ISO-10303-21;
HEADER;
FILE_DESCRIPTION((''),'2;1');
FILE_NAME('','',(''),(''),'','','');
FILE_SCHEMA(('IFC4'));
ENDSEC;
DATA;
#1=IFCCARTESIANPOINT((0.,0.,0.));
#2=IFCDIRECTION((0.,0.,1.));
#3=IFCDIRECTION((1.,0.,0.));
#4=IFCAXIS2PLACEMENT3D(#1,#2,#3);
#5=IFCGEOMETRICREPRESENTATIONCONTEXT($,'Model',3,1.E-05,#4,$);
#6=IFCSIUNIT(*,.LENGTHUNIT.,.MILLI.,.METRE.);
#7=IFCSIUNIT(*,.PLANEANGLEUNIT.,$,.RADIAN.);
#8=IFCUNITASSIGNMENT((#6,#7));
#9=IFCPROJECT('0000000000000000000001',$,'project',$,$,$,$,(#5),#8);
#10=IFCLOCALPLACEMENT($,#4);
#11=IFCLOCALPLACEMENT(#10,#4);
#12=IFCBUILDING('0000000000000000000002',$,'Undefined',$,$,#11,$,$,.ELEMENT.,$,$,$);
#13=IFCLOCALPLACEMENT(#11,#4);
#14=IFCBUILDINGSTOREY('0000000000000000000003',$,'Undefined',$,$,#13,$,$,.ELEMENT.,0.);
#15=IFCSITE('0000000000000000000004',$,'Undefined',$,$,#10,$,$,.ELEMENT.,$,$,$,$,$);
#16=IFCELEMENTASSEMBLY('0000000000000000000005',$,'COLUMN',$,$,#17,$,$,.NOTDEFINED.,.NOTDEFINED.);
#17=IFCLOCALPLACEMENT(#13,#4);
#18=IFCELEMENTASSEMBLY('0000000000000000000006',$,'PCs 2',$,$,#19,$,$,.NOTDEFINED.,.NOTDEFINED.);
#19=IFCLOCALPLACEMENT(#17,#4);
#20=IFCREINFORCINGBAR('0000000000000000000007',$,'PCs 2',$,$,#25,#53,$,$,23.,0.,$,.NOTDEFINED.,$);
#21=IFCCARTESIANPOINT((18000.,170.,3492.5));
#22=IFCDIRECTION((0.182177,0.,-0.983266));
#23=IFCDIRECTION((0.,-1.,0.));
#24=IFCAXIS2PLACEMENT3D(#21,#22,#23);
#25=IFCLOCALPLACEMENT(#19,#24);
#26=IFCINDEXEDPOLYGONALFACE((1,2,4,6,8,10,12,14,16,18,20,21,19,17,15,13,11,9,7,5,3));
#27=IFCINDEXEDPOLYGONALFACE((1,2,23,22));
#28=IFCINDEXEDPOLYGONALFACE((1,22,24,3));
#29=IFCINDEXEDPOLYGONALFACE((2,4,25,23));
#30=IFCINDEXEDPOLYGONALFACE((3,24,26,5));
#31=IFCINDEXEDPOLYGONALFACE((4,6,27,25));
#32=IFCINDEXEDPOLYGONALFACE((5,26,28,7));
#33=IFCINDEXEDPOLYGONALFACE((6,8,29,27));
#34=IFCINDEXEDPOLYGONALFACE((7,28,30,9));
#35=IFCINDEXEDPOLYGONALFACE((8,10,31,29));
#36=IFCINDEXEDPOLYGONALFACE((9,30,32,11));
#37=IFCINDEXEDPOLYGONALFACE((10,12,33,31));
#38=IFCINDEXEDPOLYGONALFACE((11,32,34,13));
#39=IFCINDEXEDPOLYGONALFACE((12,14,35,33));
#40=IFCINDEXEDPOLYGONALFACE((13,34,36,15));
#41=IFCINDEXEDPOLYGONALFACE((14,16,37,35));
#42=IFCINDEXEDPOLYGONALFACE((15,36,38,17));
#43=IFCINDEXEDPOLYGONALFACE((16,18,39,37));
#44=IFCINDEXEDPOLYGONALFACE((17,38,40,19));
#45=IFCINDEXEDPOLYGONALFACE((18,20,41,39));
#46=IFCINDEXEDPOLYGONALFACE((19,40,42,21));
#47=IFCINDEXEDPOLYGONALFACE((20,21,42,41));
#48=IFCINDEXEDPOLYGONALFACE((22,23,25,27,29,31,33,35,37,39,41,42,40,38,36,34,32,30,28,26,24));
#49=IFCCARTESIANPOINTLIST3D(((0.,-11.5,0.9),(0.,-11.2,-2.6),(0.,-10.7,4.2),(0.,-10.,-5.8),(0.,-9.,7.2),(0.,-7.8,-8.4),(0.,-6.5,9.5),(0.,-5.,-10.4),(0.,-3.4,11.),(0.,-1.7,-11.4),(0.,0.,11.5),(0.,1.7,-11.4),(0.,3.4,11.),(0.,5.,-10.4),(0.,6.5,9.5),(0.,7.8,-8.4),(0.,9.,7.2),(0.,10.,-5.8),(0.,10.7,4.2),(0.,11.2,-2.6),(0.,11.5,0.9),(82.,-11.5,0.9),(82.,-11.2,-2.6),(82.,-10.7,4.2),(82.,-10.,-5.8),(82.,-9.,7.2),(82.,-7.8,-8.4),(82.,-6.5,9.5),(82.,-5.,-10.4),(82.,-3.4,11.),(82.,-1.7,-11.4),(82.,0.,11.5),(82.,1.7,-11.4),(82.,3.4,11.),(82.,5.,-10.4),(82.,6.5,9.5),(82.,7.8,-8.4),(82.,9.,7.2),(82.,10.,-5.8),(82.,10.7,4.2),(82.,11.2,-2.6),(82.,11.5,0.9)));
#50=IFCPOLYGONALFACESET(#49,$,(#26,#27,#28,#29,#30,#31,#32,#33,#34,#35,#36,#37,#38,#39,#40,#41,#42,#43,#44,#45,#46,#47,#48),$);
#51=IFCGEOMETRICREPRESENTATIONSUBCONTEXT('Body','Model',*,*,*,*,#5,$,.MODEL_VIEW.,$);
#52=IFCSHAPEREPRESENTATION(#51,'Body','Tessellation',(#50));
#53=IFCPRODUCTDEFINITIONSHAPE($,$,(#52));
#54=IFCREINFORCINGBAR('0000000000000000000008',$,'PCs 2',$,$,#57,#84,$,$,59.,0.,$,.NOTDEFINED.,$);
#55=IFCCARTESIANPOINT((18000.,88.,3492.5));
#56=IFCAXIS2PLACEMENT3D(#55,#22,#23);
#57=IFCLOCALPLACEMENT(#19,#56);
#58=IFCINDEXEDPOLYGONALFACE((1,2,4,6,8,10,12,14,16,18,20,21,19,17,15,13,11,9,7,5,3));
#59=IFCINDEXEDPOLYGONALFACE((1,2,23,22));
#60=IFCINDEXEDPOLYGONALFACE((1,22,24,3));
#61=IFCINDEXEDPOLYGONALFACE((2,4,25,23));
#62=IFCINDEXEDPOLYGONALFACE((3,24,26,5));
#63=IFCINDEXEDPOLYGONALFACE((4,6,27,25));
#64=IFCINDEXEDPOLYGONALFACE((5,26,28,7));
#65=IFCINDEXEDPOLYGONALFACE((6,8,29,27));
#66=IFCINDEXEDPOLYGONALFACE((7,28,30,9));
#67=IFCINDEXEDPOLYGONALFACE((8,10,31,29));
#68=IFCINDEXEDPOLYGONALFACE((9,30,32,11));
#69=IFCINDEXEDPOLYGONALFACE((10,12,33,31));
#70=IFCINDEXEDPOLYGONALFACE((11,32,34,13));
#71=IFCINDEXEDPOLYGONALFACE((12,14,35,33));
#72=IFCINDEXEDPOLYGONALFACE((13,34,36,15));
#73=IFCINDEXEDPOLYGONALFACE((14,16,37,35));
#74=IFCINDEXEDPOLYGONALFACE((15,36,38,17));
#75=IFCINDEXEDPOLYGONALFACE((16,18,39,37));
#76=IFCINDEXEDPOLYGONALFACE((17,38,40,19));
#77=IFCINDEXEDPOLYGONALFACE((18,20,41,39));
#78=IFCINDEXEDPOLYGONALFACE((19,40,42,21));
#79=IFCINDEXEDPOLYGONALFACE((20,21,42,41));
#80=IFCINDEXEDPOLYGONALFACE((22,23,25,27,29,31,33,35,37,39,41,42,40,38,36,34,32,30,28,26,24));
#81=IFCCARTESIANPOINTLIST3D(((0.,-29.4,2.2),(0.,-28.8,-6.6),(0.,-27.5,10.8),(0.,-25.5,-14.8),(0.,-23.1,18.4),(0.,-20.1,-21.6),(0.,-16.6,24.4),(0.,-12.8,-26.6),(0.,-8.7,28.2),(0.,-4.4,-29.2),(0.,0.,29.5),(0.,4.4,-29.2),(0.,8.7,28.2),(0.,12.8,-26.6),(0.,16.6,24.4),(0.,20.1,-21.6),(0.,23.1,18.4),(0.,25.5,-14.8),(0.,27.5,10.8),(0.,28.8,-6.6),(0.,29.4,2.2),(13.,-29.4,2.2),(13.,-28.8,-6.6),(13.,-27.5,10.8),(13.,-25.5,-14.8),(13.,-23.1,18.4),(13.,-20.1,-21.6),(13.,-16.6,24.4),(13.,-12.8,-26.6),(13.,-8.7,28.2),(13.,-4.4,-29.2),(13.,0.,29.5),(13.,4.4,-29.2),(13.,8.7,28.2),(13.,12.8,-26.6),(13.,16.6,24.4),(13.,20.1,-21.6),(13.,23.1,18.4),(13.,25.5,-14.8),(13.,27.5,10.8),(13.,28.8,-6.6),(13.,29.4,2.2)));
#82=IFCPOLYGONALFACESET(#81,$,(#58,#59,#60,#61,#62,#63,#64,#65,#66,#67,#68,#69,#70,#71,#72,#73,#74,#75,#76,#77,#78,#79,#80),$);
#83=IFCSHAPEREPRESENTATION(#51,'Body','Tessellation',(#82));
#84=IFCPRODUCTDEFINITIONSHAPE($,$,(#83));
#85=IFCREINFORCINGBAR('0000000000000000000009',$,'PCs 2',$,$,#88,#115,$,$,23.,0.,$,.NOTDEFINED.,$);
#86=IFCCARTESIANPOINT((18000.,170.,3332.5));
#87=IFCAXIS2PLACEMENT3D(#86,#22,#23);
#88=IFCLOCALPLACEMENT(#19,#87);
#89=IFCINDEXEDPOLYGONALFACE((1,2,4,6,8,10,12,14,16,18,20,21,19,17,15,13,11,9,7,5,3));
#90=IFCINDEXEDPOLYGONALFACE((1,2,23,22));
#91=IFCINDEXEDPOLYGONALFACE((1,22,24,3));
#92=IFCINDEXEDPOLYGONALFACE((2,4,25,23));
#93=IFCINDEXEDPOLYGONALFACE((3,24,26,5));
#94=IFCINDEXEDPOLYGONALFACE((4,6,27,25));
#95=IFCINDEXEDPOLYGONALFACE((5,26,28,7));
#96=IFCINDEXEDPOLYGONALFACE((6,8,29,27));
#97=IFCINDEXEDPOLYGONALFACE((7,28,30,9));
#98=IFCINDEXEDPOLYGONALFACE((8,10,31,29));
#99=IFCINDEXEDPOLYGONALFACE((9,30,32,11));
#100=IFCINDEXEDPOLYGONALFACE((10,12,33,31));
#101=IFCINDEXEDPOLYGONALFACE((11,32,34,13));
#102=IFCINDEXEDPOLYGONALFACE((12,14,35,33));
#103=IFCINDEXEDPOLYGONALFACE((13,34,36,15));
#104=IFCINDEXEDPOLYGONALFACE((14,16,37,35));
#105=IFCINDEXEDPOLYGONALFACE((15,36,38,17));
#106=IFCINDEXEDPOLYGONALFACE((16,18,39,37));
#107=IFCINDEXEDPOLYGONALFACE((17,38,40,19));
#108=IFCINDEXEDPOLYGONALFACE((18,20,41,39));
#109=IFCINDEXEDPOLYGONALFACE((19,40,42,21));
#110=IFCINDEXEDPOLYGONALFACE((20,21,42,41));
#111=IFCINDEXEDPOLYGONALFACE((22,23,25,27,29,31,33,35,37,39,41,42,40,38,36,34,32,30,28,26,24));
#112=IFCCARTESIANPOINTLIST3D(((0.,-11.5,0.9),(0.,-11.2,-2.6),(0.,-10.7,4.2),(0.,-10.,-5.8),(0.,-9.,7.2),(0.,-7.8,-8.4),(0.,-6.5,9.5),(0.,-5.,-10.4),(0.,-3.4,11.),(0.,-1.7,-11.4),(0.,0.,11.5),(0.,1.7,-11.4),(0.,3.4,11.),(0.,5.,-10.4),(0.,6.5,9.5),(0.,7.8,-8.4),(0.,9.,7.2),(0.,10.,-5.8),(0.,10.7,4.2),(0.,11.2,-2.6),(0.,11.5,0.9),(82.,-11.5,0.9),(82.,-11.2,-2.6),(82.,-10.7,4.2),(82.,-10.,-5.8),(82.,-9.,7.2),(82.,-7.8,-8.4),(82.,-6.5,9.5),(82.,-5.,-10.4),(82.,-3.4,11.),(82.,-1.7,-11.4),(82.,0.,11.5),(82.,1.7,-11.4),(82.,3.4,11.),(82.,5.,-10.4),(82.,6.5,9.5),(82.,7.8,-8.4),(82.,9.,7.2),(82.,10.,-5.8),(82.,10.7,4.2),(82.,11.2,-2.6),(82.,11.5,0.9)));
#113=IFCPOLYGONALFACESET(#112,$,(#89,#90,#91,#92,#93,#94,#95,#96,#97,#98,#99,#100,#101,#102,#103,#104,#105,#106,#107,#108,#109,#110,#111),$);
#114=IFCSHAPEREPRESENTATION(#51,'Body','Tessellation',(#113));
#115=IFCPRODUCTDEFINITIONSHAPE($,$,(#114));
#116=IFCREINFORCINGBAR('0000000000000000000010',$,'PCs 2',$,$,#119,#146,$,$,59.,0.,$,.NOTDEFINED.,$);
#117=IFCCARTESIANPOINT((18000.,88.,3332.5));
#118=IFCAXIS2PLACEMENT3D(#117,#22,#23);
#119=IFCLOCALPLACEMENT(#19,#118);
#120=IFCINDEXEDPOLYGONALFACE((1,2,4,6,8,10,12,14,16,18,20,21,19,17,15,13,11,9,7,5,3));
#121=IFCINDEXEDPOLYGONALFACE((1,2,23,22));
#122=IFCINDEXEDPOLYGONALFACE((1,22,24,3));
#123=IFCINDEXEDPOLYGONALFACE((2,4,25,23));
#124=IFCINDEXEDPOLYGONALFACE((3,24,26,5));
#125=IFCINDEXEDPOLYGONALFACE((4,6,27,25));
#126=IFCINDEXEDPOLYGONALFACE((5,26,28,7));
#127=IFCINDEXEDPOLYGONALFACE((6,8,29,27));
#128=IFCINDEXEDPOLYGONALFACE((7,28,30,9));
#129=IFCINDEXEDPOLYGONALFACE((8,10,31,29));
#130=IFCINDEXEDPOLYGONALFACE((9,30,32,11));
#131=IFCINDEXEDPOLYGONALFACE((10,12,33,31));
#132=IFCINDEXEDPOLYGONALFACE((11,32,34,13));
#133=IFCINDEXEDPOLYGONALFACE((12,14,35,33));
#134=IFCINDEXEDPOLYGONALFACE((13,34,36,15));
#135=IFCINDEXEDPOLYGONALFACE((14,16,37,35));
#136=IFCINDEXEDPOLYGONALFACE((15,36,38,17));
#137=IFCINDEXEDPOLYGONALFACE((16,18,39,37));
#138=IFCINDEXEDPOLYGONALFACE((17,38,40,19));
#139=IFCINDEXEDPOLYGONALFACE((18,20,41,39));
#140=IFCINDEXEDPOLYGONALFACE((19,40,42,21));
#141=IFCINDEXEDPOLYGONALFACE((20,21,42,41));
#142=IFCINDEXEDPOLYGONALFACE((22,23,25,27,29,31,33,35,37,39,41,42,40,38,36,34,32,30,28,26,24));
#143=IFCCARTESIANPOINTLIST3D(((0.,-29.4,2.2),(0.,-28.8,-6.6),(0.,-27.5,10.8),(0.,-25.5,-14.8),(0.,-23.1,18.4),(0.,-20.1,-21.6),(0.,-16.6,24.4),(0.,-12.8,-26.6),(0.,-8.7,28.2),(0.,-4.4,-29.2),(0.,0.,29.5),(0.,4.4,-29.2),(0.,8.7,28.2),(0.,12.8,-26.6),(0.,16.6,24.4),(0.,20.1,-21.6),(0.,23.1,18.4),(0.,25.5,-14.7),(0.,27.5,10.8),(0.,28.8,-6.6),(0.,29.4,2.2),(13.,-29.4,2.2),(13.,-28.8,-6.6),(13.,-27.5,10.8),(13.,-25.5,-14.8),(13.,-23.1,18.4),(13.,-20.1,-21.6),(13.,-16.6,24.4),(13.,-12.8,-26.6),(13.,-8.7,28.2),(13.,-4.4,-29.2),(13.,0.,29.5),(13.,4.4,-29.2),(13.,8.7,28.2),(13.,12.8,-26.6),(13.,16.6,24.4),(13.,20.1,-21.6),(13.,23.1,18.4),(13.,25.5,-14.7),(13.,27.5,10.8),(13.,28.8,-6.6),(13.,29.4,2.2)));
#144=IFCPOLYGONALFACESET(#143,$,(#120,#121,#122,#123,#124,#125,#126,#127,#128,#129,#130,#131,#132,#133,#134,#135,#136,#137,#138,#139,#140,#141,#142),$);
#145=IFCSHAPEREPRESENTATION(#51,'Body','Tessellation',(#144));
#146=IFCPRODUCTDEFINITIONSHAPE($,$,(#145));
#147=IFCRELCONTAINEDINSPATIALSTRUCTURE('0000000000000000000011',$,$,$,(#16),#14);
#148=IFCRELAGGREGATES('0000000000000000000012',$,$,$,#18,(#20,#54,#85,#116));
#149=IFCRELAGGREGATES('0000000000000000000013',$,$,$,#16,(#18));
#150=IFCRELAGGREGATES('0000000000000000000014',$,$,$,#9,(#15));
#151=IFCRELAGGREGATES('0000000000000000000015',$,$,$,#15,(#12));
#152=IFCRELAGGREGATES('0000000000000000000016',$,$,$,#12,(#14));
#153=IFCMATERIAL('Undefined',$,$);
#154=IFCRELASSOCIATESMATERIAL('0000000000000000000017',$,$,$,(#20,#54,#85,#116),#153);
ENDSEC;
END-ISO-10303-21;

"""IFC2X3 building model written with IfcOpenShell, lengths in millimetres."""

from ifc_helpers import new_model, entity, si_unit, frame, origin_with_axes, place, context, subcontext, project, spatial, source, transform, mapped, material, element, aggregate, save


model = new_model("IFC2X3")

# Units and contexts
model_context = context("Model", 3, precision=1e-05, world=origin_with_axes())
body_context = subcontext(model_context, "Body", "Model", "MODEL_VIEW")
ifc_project = project(units=[si_unit("LENGTHUNIT", "METRE", prefix="MILLI"), si_unit("PLANEANGLEUNIT", "RADIAN")], contexts=[model_context])

# Site, building, storey
site_placement = place(None, origin_with_axes())
site = spatial("IfcSite", under=ifc_project, at=site_placement, Name="Undefined", CompositionType="ELEMENT")
building_placement = place(site_placement, origin_with_axes())
building = spatial("IfcBuilding", under=site, at=building_placement, Name="Undefined", CompositionType="ELEMENT")
storey_placement = place(building_placement, origin_with_axes())
storey = spatial("IfcBuildingStorey", under=building, at=storey_placement, Name="Undefined", CompositionType="ELEMENT", Elevation=0.0)

# Shared definitions
ifc_material_1 = material(Name="Undefined")

# Element assemblies, reinforcing bars
assembly_1_placement = place(storey_placement, origin_with_axes())
assembly_1 = element("IfcElementAssembly", 1, at=assembly_1_placement, inside=storey, Name="COLUMN", AssemblyPlace="NOTDEFINED", PredefinedType="NOTDEFINED")
assembly_2_placement = place(assembly_1_placement, origin_with_axes())
assembly_2 = element("IfcElementAssembly", 2, at=assembly_2_placement, Name="PCs 2", AssemblyPlace="NOTDEFINED", PredefinedType="NOTDEFINED")
shared_shape_1 = source(origin_with_axes(), body_context, "Body", "AdvancedSweptSolid", [
    entity("IfcSweptDiskSolid", entity("IfcTrimmedCurve", entity("IfcLine", entity("IfcCartesianPoint", [0.0, 0.0, 0.0]), entity("IfcVector", entity("IfcDirection", [1.0, 0.0, 0.0]), 1.0)), [entity("IfcParameterValue", 0.0)], [entity("IfcParameterValue", 82.0)], True, "PARAMETER"), 11.5, None, 0.0, 82.0),
])
reinforcing_bar_1_placement = place(assembly_2_placement, frame((18000.0, 170.0, 3492.5), z_axis=(0.182177, 0.0, -0.983266), x_axis=(0.0, -1.0, 0.0)))
reinforcing_bar_1 = element("IfcReinforcingBar", 3, at=reinforcing_bar_1_placement, material=ifc_material_1, Name="PCs 2", BarRole="NOTDEFINED", CrossSectionArea=0.0, NominalDiameter=23.0, context=body_context, shape_type="MappedRepresentation", body=[
    mapped(shared_shape_1, transform((0.0, 0.0, 0.0))),
])
shared_shape_2 = source(origin_with_axes(), body_context, "Body", "AdvancedSweptSolid", [
    entity("IfcSweptDiskSolid", entity("IfcTrimmedCurve", entity("IfcLine", entity("IfcCartesianPoint", [0.0, 0.0, 0.0]), entity("IfcVector", entity("IfcDirection", [1.0, 0.0, 0.0]), 1.0)), [entity("IfcParameterValue", 0.0)], [entity("IfcParameterValue", 13.0)], True, "PARAMETER"), 29.5, None, 0.0, 13.0),
])
reinforcing_bar_2_placement = place(assembly_2_placement, frame((18000.0, 88.0, 3492.5), z_axis=(0.182177, 0.0, -0.983266), x_axis=(0.0, -1.0, 0.0)))
reinforcing_bar_2 = element("IfcReinforcingBar", 4, at=reinforcing_bar_2_placement, material=ifc_material_1, Name="PCs 2", BarRole="NOTDEFINED", CrossSectionArea=0.0, NominalDiameter=59.0, context=body_context, shape_type="MappedRepresentation", body=[
    mapped(shared_shape_2, transform((0.0, 0.0, 0.0))),
])
shared_shape_3 = source(origin_with_axes(), body_context, "Body", "AdvancedSweptSolid", [
    entity("IfcSweptDiskSolid", entity("IfcTrimmedCurve", entity("IfcLine", entity("IfcCartesianPoint", [0.0, 0.0, 0.0]), entity("IfcVector", entity("IfcDirection", [1.0, 0.0, 0.0]), 1.0)), [entity("IfcParameterValue", 0.0)], [entity("IfcParameterValue", 82.0)], True, "PARAMETER"), 11.5, None, 0.0, 82.0),
])
reinforcing_bar_3_placement = place(assembly_2_placement, frame((18000.0, 170.0, 3332.5), z_axis=(0.182177, 0.0, -0.983266), x_axis=(0.0, -1.0, 0.0)))
reinforcing_bar_3 = element("IfcReinforcingBar", 5, at=reinforcing_bar_3_placement, material=ifc_material_1, Name="PCs 2", BarRole="NOTDEFINED", CrossSectionArea=0.0, NominalDiameter=23.0, context=body_context, shape_type="MappedRepresentation", body=[
    mapped(shared_shape_3, transform((0.0, 0.0, 0.0))),
])
shared_shape_4 = source(origin_with_axes(), body_context, "Body", "AdvancedSweptSolid", [
    entity("IfcSweptDiskSolid", entity("IfcTrimmedCurve", entity("IfcLine", entity("IfcCartesianPoint", [0.0, 0.0, 0.0]), entity("IfcVector", entity("IfcDirection", [1.0, 0.0, 0.0]), 1.0)), [entity("IfcParameterValue", 0.0)], [entity("IfcParameterValue", 13.0)], True, "PARAMETER"), 29.5, None, 0.0, 13.0),
])
reinforcing_bar_4_placement = place(assembly_2_placement, frame((18000.0, 88.0, 3332.5), z_axis=(0.182177, 0.0, -0.983266), x_axis=(0.0, -1.0, 0.0)))
reinforcing_bar_4 = element("IfcReinforcingBar", 6, at=reinforcing_bar_4_placement, material=ifc_material_1, Name="PCs 2", BarRole="NOTDEFINED", CrossSectionArea=0.0, NominalDiameter=59.0, context=body_context, shape_type="MappedRepresentation", body=[
    mapped(shared_shape_4, transform((0.0, 0.0, 0.0))),
])
aggregate(assembly_2, [reinforcing_bar_1, reinforcing_bar_2, reinforcing_bar_3, reinforcing_bar_4])
aggregate(assembly_1, [assembly_2])

save(model, "model.ifc")
